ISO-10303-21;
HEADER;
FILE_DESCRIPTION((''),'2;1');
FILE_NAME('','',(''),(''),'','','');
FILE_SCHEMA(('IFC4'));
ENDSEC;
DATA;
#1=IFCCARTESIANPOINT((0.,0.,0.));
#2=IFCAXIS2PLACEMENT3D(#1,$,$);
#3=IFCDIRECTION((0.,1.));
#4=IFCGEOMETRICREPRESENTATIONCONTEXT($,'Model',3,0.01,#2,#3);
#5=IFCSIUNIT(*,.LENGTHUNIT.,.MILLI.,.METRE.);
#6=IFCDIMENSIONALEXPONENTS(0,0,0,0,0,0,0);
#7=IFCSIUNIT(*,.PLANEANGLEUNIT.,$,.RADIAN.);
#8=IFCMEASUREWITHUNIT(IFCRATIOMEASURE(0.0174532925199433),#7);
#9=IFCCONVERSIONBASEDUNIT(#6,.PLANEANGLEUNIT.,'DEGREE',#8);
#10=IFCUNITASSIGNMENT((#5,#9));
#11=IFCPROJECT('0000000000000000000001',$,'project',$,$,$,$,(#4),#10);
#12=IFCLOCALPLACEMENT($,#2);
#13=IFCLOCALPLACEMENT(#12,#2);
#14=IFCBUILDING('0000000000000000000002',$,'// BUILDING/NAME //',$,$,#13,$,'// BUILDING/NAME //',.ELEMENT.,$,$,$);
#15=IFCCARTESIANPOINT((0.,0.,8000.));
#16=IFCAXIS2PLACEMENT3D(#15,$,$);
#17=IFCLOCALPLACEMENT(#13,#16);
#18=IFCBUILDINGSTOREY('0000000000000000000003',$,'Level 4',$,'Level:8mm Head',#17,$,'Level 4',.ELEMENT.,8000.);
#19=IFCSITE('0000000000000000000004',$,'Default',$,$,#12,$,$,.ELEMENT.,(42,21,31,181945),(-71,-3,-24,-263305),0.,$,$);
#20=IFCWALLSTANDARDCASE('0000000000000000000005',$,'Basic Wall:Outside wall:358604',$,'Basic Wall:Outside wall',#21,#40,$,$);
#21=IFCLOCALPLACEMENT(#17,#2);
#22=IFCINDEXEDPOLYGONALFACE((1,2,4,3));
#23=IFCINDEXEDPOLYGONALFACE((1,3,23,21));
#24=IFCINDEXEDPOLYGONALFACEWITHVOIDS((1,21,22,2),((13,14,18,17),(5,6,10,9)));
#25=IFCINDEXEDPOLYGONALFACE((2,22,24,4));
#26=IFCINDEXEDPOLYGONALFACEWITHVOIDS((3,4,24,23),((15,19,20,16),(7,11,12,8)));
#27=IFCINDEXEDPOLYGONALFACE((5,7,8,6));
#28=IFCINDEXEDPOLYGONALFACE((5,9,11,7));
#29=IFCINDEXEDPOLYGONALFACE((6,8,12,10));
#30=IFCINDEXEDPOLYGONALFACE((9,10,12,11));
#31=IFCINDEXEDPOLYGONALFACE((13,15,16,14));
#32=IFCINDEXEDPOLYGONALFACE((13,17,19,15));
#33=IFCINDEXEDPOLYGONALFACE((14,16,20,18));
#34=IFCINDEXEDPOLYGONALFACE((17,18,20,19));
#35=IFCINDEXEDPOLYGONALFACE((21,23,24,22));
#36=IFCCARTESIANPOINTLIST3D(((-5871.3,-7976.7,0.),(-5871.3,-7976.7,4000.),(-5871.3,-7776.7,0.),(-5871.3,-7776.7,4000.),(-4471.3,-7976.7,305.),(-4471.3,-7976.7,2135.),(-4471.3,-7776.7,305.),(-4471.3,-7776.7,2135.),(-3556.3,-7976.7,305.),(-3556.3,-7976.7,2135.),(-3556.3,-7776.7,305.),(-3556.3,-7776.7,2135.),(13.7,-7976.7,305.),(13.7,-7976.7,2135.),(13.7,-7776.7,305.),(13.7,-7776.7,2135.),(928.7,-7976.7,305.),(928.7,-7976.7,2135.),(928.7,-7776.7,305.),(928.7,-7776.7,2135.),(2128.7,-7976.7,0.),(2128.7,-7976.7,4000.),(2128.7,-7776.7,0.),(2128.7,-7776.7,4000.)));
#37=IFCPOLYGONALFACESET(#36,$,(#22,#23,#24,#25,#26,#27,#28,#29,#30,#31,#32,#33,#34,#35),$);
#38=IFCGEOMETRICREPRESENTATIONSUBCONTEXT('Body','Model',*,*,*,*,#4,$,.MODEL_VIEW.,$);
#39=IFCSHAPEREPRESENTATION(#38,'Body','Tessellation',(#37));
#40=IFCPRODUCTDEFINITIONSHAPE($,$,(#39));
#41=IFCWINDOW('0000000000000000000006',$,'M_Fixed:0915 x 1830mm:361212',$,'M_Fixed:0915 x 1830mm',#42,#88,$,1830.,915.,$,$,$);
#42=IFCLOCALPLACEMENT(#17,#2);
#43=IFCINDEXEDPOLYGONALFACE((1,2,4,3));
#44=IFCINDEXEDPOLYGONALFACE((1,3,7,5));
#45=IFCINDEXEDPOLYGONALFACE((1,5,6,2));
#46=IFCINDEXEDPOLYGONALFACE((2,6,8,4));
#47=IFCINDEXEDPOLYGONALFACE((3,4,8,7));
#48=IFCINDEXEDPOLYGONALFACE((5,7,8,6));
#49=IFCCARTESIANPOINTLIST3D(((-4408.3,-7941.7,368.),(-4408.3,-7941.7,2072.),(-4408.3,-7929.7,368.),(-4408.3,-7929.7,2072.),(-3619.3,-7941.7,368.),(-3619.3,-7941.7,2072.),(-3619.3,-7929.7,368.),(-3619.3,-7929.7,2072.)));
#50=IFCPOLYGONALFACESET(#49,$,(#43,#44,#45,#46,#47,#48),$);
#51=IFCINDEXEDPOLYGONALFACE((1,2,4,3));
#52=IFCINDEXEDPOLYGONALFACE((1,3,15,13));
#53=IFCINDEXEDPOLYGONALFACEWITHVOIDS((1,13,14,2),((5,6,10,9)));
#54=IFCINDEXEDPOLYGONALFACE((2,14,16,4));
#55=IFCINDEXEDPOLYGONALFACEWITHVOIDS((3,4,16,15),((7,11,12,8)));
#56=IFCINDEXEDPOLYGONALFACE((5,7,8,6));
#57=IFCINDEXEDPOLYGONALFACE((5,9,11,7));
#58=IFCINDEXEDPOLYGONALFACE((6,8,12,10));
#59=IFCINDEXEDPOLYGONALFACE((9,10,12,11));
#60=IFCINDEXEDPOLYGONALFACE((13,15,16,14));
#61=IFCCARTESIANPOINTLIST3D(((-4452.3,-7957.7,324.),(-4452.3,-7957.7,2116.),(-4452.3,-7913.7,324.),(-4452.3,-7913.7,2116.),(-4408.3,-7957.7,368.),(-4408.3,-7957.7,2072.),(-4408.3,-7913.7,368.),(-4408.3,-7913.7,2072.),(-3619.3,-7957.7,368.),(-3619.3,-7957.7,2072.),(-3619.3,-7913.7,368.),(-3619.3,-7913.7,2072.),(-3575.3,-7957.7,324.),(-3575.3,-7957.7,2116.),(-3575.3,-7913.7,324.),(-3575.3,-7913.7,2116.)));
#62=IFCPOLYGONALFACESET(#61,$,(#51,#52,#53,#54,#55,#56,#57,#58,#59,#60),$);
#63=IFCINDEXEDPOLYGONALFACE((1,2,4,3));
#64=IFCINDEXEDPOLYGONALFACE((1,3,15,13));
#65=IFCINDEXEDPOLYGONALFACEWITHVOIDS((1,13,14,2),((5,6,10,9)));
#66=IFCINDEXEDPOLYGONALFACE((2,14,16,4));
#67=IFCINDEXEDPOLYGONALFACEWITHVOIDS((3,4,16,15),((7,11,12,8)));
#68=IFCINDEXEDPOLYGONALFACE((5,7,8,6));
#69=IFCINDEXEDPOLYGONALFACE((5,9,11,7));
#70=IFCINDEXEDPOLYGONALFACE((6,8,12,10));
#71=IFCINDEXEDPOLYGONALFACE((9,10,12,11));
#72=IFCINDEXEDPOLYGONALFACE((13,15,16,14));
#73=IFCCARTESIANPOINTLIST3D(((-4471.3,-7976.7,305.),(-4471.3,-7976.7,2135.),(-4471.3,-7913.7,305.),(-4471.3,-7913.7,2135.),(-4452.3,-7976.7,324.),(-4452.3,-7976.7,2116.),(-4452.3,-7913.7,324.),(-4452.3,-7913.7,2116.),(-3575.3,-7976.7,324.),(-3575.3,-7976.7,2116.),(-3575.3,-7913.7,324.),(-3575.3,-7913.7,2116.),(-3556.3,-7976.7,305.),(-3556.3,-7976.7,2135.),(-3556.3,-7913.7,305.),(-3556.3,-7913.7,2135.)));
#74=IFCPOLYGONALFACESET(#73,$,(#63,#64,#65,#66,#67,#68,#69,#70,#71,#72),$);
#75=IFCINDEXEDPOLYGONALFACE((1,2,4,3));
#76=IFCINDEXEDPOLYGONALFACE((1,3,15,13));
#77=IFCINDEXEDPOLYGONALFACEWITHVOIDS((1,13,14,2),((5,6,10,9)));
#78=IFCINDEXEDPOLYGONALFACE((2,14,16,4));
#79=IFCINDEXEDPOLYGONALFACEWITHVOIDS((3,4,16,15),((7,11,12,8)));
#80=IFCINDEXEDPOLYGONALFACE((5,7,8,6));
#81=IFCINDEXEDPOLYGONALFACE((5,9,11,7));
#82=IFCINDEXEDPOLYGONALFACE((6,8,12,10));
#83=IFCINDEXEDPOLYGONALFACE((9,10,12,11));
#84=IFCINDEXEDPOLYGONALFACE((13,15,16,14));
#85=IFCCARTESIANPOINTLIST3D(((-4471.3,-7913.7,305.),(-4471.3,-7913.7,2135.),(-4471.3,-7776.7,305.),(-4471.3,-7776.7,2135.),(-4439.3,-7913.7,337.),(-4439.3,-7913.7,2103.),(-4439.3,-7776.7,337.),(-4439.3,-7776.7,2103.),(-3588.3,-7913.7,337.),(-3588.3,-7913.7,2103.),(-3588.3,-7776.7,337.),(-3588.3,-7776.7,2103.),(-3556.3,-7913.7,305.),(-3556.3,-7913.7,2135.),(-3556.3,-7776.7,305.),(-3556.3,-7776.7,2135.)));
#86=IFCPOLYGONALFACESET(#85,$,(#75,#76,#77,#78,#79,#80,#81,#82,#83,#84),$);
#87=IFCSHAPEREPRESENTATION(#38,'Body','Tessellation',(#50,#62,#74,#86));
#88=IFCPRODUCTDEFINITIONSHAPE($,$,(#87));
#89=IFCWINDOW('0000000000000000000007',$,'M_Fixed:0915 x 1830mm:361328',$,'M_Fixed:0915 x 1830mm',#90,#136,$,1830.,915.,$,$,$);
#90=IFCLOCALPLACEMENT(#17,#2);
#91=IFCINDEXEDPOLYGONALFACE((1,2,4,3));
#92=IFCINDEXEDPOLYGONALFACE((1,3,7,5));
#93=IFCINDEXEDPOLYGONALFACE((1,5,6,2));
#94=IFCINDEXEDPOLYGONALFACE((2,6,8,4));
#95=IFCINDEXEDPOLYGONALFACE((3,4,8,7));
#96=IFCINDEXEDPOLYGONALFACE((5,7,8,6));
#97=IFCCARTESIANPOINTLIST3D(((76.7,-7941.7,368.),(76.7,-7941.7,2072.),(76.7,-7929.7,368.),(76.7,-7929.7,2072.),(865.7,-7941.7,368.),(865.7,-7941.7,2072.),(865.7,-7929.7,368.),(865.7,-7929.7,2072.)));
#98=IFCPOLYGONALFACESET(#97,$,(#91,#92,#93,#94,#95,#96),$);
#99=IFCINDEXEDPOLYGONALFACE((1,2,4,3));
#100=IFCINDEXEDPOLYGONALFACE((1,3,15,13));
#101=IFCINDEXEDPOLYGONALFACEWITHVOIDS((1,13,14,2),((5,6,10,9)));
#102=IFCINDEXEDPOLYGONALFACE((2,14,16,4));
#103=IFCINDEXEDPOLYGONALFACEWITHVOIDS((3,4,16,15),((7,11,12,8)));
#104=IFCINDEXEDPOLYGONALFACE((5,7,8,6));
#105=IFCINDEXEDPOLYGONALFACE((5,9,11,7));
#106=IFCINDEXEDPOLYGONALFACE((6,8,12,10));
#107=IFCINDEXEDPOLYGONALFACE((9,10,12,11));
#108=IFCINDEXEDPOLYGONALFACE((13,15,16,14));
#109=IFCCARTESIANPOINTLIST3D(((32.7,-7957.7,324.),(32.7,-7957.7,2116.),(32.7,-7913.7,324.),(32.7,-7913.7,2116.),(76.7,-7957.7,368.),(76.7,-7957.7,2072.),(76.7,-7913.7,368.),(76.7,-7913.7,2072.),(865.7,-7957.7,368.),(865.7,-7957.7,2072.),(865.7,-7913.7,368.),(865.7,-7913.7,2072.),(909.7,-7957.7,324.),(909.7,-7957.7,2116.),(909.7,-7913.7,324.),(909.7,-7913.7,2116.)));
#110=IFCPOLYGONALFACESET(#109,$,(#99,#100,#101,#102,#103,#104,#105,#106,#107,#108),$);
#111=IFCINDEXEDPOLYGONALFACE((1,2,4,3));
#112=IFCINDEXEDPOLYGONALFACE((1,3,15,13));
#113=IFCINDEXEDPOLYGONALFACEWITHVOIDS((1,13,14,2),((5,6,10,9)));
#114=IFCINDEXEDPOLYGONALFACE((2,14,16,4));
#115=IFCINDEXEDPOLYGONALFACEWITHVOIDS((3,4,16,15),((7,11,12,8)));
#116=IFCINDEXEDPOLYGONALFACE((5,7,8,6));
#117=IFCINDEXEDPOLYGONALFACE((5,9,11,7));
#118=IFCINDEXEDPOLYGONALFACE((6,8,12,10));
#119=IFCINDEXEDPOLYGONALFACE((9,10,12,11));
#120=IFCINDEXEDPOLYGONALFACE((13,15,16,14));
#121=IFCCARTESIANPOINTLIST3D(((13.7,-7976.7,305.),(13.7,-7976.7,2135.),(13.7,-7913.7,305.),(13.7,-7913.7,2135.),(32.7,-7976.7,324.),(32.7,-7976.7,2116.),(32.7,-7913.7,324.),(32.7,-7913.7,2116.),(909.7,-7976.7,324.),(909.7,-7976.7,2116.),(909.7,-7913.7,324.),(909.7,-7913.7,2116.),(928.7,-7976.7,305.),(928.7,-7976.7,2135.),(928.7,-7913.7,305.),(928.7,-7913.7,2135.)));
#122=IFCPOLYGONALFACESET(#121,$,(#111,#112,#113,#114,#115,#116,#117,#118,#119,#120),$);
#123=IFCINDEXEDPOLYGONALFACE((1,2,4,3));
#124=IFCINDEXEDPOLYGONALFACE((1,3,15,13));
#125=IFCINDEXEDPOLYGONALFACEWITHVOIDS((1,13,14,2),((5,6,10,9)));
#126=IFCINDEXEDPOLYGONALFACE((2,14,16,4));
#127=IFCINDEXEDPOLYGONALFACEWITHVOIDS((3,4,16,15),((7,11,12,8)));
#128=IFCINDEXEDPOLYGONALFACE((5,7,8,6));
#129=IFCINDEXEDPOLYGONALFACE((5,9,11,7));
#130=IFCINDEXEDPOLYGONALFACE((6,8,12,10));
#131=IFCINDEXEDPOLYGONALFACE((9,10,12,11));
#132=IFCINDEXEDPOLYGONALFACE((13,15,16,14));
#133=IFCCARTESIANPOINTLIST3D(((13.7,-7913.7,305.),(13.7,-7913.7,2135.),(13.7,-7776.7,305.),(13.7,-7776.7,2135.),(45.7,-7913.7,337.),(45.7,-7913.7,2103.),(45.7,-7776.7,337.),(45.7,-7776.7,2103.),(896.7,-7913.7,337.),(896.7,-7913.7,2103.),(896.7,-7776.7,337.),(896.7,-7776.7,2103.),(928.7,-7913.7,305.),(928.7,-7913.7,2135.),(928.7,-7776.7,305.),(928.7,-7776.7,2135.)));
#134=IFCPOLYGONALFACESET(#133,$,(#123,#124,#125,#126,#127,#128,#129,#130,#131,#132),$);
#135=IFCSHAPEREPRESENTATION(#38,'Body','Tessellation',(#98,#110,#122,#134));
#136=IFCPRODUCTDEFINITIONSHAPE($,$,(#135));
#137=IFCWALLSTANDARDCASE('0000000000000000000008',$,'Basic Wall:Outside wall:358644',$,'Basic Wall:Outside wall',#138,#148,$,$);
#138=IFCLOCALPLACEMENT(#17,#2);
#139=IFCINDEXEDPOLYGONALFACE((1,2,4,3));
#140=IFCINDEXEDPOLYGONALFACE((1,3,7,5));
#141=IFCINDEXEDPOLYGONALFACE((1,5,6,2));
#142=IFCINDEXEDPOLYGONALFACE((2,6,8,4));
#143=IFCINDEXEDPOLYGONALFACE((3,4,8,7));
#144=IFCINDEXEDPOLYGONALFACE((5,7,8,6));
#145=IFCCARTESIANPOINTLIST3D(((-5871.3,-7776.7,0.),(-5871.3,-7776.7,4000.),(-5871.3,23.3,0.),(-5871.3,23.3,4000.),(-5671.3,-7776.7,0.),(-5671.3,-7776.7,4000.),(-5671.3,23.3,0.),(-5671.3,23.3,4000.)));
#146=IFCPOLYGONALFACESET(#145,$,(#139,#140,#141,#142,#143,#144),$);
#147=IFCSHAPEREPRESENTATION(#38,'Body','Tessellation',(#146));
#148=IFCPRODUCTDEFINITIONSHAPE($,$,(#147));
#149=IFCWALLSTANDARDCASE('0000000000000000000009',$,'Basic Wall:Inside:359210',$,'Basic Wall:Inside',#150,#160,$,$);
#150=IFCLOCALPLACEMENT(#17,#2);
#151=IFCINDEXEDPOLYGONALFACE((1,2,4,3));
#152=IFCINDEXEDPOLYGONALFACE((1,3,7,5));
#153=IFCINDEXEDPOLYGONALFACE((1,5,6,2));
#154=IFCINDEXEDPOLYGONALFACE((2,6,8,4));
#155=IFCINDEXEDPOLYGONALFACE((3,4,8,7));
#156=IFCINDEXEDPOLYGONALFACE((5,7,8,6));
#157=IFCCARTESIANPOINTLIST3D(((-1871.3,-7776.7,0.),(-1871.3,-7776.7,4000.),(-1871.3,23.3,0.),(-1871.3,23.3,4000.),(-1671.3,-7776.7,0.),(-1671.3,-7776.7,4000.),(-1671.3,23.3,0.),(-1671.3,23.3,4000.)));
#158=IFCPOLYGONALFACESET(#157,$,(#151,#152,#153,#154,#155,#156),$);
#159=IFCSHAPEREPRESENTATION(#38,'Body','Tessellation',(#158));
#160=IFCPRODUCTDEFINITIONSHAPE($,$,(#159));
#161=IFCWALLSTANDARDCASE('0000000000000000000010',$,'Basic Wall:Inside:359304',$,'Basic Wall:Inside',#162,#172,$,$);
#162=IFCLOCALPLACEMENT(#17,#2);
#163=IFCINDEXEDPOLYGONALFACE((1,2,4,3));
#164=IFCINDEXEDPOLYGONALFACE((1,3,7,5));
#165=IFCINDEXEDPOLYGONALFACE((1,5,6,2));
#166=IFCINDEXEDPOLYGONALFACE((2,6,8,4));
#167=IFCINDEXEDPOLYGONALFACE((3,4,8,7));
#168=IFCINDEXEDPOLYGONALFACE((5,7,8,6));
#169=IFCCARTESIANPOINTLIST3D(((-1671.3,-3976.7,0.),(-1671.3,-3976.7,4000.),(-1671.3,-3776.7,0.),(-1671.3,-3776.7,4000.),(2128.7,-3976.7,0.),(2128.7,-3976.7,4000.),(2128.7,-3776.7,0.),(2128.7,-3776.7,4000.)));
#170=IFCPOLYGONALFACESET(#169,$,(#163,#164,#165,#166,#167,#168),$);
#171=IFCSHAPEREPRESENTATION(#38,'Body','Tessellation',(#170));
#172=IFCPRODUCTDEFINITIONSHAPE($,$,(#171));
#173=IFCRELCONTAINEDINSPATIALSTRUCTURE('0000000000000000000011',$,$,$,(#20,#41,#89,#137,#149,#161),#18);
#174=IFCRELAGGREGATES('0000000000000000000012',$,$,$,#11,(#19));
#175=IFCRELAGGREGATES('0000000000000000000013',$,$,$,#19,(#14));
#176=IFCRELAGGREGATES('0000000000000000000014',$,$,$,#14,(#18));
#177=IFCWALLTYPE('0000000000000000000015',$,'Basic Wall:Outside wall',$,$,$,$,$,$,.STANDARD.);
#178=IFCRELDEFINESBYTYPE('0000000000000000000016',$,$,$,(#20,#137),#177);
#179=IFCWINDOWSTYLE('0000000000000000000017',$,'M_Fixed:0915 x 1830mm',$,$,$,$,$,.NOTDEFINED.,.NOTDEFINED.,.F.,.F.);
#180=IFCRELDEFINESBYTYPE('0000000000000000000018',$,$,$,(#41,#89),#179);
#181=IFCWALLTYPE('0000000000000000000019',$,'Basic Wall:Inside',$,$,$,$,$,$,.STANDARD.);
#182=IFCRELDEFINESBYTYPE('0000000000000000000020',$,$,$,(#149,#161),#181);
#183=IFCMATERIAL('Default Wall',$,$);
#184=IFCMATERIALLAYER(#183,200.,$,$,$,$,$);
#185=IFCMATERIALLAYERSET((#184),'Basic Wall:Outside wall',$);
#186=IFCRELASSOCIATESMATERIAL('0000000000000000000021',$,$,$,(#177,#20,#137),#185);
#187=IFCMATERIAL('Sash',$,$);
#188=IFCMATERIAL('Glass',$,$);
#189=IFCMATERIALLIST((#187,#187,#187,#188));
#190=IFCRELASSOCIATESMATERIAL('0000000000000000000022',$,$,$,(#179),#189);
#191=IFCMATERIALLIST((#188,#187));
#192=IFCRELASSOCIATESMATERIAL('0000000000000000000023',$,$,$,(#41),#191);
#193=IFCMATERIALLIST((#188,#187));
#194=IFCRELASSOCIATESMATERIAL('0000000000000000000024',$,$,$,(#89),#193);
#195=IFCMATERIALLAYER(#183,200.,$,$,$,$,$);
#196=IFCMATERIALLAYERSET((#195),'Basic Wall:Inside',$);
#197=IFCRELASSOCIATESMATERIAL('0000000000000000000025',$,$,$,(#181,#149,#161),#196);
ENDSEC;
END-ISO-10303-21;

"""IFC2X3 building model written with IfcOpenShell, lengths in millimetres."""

from ifc_helpers import new_model, entity, si_unit, converted_unit, direction, frame, frame_2d, origin, place, context, subcontext, project, spatial, polyline, rectangle, outline, extrude, clip, halfspace, source, transform, mapped, material, material_list, layer, layer_set, layer_usage, type_object, type_shapes, element, fill, save


model = new_model("IFC2X3")

# Units and contexts
model_context = context("Model", 3, precision=0.01, world=origin(), true_north=direction((0.0, 1.0)))
body_context = subcontext(model_context, "Body", "Model", "MODEL_VIEW")
ifc_project = project(units=[si_unit("LENGTHUNIT", "METRE", prefix="MILLI"), converted_unit("PLANEANGLEUNIT", "DEGREE", entity("IfcRatioMeasure", 0.0174532925199433), si_unit("PLANEANGLEUNIT", "RADIAN"), dimensions=[0, 0, 0, 0, 0, 0, 0])], contexts=[model_context])

# Site, building, storey
site_placement = place(None, origin())
site = spatial("IfcSite", under=ifc_project, at=site_placement, Name="Default", CompositionType="ELEMENT", RefLatitude=(42, 21, 31, 181945), RefLongitude=(-71, -3, -24, -263305), RefElevation=0.0)
building_placement = place(site_placement, origin())
building = spatial("IfcBuilding", under=site, at=building_placement, Name="// BUILDING/NAME //", LongName="// BUILDING/NAME //", CompositionType="ELEMENT")
storey_placement = place(building_placement, frame((0.0, 0.0, 8000.0)))
storey = spatial("IfcBuildingStorey", under=building, at=storey_placement, Name="Level 4", ObjectType="Level:8mm Head", LongName="Level 4", CompositionType="ELEMENT", Elevation=8000.0)

# Shared definitions
ifc_material_1 = material(Name="Default Wall")
ifc_layer_1 = layer(ifc_material_1, 200.0)
ifc_layer_set_1 = layer_set([ifc_layer_1], Name="Basic Wall:Outside wall")
wall_type_1 = type_object("IfcWallType", Name="Basic Wall:Outside wall", PredefinedType="STANDARD", material=ifc_layer_set_1)
ifc_material_2 = material(Name="Glass")
ifc_material_3 = material(Name="Sash")
ifc_material_list_1 = material_list([ifc_material_3, ifc_material_3, ifc_material_3, ifc_material_2])
window_style = type_object("IfcWindowStyle", Name="M_Fixed:0915 x 1830mm", ConstructionType="NOTDEFINED", OperationType="NOTDEFINED", ParameterTakesPrecedence=False, Sizeable=False, material=ifc_material_list_1)
shared_shape = source(origin(), body_context, "Body", "SweptSolid", [
    extrude(rectangle(XDim=12.0, YDim=789.0, at=frame_2d((0.0, 0.0), x_axis=(1.0, 0.0))), frame((457.5, 159.0, 63.0), z_axis=(0.0, 0.0, 1.0), x_axis=(0.0, -1.0, 0.0)), (0.0, 0.0, 1.0), 1704.0),
    extrude(outline(polyline([(-438.5, -896.0), (438.5, -896.0), (438.5, 896.0), (-438.5, 896.0), (-438.5, -896.0)]), holes=[polyline([(-394.5, -852.0), (-394.5, 852.0), (394.5, 852.0), (394.5, -852.0), (-394.5, -852.0)])]), frame((457.5, 137.0, 915.0), z_axis=(0.0, 1.0, 0.0), x_axis=(1.0, 0.0, 0.0)), (0.0, 0.0, 1.0), 44.0),
    extrude(outline(polyline([(-457.5, -915.0), (457.5, -915.0), (457.5, 915.0), (-457.5, 915.0), (-457.5, -915.0)]), holes=[polyline([(-438.5, -896.0), (-438.5, 896.0), (438.5, 896.0), (438.5, -896.0), (-438.5, -896.0)])]), frame((457.5, 137.0, 915.0), z_axis=(0.0, 1.0, 0.0), x_axis=(1.0, 0.0, 0.0)), (0.0, 0.0, 1.0), 63.0),
    extrude(outline(polyline([(-457.5, -915.0), (457.5, -915.0), (457.5, 915.0), (-457.5, 915.0), (-457.5, -915.0)]), holes=[polyline([(-425.5, -883.0), (-425.5, 883.0), (425.5, 883.0), (425.5, -883.0), (-425.5, -883.0)])]), frame((457.5, 0.0, 915.0), z_axis=(0.0, 1.0, 0.0), x_axis=(1.0, 0.0, 0.0)), (0.0, 0.0, 1.0), 137.0),
])
type_shapes(window_style, [shared_shape])

# Wall, openings, windows
ifc_layer_usage_1 = layer_usage(ifc_layer_set_1, "AXIS2", "NEGATIVE", 100.0)
wall_1_placement = place(storey_placement, frame((2128.7, -7876.7, 0.0), z_axis=(0.0, 0.0, 1.0), x_axis=(-1.0, 0.0, 0.0)))
wall_1 = element("IfcWallStandardCase", 1, at=wall_1_placement, inside=storey, type_object=wall_type_1, material=ifc_layer_usage_1, Name="Basic Wall:Outside wall:358604", ObjectType="Basic Wall:Outside wall", context=body_context, shape_type="Clipping", body=[
    clip(extrude(rectangle(XDim=8000.0, YDim=200.0, at=frame_2d((4000.0, 0.0), x_axis=(-1.0, 0.0))), origin(), (0.0, 0.0, 1.0), 4000.0), halfspace(frame((0.0, 0.0, -8000.0)), True)),
])
opening_1_placement = place(wall_1_placement, frame((5685.0, -100.0, 305.0)))
opening_1 = element("IfcOpeningElement", 2, at=opening_1_placement, cuts=wall_1, ObjectType="Opening", context=body_context, shape_type="SweptSolid", body=[
    extrude(rectangle(XDim=1830.0, YDim=915.0, at=frame_2d((915.0, 457.5), x_axis=(1.0, 0.0))), frame((0.0, 0.0, 0.0), z_axis=(0.0, 1.0, 0.0), x_axis=(0.0, 0.0, 1.0)), (0.0, 0.0, 1.0), 200.0),
])
opening_2_placement = place(wall_1_placement, frame((1200.0, -100.0, 305.0)))
opening_2 = element("IfcOpeningElement", 3, at=opening_2_placement, cuts=wall_1, ObjectType="Opening", context=body_context, shape_type="SweptSolid", body=[
    extrude(rectangle(XDim=1830.0, YDim=915.0, at=frame_2d((915.0, 457.5), x_axis=(1.0, 0.0))), frame((0.0, 0.0, 0.0), z_axis=(0.0, 1.0, 0.0), x_axis=(0.0, 0.0, 1.0)), (0.0, 0.0, 1.0), 200.0),
])
ifc_material_list_2 = material_list([ifc_material_2, ifc_material_3])
window_1_placement = place(opening_1_placement, origin())
window_1 = element("IfcWindow", 4, at=window_1_placement, inside=storey, type_object=window_style, material=ifc_material_list_2, Name="M_Fixed:0915 x 1830mm:361212", ObjectType="M_Fixed:0915 x 1830mm", OverallHeight=1830.0, OverallWidth=915.0, context=body_context, shape_type="MappedRepresentation", body=[
    mapped(shared_shape, transform((0.0, 0.0, 0.0), scale=1.0)),
])
fill(opening_1, window_1)
ifc_material_list_3 = material_list([ifc_material_2, ifc_material_3])
window_2_placement = place(opening_2_placement, origin())
window_2 = element("IfcWindow", 5, at=window_2_placement, inside=storey, type_object=window_style, material=ifc_material_list_3, Name="M_Fixed:0915 x 1830mm:361328", ObjectType="M_Fixed:0915 x 1830mm", OverallHeight=1830.0, OverallWidth=915.0, context=body_context, shape_type="MappedRepresentation", body=[
    mapped(shared_shape, transform((0.0, 0.0, 0.0), scale=1.0)),
])
fill(opening_2, window_2)

# Walls
ifc_layer_usage_2 = layer_usage(ifc_layer_set_1, "AXIS2", "NEGATIVE", 100.0)
wall_2_placement = place(storey_placement, frame((-5771.3, -7776.7, 0.0), z_axis=(0.0, 0.0, 1.0), x_axis=(0.0, 1.0, 0.0)))
element("IfcWallStandardCase", 6, at=wall_2_placement, inside=storey, type_object=wall_type_1, material=ifc_layer_usage_2, Name="Basic Wall:Outside wall:358644", ObjectType="Basic Wall:Outside wall", context=body_context, shape_type="Clipping", body=[
    clip(extrude(rectangle(XDim=7800.0, YDim=200.0, at=frame_2d((3900.0, 0.0), x_axis=(-1.0, 0.0))), origin(), (0.0, 0.0, 1.0), 4000.0), halfspace(frame((0.0, 0.0, -8000.0)), True)),
])
ifc_layer_2 = layer(ifc_material_1, 200.0)
ifc_layer_set_2 = layer_set([ifc_layer_2], Name="Basic Wall:Inside")
ifc_layer_usage_3 = layer_usage(ifc_layer_set_2, "AXIS2", "NEGATIVE", 100.0)
wall_type_2 = type_object("IfcWallType", Name="Basic Wall:Inside", PredefinedType="STANDARD", material=ifc_layer_set_2)
wall_3_placement = place(storey_placement, frame((-1771.3, 23.3, 0.0), z_axis=(0.0, 0.0, 1.0), x_axis=(0.0, -1.0, 0.0)))
element("IfcWallStandardCase", 7, at=wall_3_placement, inside=storey, type_object=wall_type_2, material=ifc_layer_usage_3, Name="Basic Wall:Inside:359210", ObjectType="Basic Wall:Inside", context=body_context, shape_type="Clipping", body=[
    clip(extrude(rectangle(XDim=7800.0, YDim=200.0, at=frame_2d((3900.0, 0.0), x_axis=(-1.0, 0.0))), origin(), (0.0, 0.0, 1.0), 4000.0), halfspace(frame((0.0, 0.0, -8000.0)), True)),
])
ifc_layer_usage_4 = layer_usage(ifc_layer_set_2, "AXIS2", "NEGATIVE", 100.0)
wall_4_placement = place(storey_placement, frame((-1671.3, -3876.7, 0.0)))
element("IfcWallStandardCase", 8, at=wall_4_placement, inside=storey, type_object=wall_type_2, material=ifc_layer_usage_4, Name="Basic Wall:Inside:359304", ObjectType="Basic Wall:Inside", context=body_context, shape_type="Clipping", body=[
    clip(extrude(rectangle(XDim=3800.0, YDim=200.0, at=frame_2d((1900.0, 0.0), x_axis=(-1.0, 0.0))), origin(), (0.0, 0.0, 1.0), 4000.0), halfspace(frame((0.0, 0.0, -8000.0)), True)),
])

save(model, "model.ifc")
